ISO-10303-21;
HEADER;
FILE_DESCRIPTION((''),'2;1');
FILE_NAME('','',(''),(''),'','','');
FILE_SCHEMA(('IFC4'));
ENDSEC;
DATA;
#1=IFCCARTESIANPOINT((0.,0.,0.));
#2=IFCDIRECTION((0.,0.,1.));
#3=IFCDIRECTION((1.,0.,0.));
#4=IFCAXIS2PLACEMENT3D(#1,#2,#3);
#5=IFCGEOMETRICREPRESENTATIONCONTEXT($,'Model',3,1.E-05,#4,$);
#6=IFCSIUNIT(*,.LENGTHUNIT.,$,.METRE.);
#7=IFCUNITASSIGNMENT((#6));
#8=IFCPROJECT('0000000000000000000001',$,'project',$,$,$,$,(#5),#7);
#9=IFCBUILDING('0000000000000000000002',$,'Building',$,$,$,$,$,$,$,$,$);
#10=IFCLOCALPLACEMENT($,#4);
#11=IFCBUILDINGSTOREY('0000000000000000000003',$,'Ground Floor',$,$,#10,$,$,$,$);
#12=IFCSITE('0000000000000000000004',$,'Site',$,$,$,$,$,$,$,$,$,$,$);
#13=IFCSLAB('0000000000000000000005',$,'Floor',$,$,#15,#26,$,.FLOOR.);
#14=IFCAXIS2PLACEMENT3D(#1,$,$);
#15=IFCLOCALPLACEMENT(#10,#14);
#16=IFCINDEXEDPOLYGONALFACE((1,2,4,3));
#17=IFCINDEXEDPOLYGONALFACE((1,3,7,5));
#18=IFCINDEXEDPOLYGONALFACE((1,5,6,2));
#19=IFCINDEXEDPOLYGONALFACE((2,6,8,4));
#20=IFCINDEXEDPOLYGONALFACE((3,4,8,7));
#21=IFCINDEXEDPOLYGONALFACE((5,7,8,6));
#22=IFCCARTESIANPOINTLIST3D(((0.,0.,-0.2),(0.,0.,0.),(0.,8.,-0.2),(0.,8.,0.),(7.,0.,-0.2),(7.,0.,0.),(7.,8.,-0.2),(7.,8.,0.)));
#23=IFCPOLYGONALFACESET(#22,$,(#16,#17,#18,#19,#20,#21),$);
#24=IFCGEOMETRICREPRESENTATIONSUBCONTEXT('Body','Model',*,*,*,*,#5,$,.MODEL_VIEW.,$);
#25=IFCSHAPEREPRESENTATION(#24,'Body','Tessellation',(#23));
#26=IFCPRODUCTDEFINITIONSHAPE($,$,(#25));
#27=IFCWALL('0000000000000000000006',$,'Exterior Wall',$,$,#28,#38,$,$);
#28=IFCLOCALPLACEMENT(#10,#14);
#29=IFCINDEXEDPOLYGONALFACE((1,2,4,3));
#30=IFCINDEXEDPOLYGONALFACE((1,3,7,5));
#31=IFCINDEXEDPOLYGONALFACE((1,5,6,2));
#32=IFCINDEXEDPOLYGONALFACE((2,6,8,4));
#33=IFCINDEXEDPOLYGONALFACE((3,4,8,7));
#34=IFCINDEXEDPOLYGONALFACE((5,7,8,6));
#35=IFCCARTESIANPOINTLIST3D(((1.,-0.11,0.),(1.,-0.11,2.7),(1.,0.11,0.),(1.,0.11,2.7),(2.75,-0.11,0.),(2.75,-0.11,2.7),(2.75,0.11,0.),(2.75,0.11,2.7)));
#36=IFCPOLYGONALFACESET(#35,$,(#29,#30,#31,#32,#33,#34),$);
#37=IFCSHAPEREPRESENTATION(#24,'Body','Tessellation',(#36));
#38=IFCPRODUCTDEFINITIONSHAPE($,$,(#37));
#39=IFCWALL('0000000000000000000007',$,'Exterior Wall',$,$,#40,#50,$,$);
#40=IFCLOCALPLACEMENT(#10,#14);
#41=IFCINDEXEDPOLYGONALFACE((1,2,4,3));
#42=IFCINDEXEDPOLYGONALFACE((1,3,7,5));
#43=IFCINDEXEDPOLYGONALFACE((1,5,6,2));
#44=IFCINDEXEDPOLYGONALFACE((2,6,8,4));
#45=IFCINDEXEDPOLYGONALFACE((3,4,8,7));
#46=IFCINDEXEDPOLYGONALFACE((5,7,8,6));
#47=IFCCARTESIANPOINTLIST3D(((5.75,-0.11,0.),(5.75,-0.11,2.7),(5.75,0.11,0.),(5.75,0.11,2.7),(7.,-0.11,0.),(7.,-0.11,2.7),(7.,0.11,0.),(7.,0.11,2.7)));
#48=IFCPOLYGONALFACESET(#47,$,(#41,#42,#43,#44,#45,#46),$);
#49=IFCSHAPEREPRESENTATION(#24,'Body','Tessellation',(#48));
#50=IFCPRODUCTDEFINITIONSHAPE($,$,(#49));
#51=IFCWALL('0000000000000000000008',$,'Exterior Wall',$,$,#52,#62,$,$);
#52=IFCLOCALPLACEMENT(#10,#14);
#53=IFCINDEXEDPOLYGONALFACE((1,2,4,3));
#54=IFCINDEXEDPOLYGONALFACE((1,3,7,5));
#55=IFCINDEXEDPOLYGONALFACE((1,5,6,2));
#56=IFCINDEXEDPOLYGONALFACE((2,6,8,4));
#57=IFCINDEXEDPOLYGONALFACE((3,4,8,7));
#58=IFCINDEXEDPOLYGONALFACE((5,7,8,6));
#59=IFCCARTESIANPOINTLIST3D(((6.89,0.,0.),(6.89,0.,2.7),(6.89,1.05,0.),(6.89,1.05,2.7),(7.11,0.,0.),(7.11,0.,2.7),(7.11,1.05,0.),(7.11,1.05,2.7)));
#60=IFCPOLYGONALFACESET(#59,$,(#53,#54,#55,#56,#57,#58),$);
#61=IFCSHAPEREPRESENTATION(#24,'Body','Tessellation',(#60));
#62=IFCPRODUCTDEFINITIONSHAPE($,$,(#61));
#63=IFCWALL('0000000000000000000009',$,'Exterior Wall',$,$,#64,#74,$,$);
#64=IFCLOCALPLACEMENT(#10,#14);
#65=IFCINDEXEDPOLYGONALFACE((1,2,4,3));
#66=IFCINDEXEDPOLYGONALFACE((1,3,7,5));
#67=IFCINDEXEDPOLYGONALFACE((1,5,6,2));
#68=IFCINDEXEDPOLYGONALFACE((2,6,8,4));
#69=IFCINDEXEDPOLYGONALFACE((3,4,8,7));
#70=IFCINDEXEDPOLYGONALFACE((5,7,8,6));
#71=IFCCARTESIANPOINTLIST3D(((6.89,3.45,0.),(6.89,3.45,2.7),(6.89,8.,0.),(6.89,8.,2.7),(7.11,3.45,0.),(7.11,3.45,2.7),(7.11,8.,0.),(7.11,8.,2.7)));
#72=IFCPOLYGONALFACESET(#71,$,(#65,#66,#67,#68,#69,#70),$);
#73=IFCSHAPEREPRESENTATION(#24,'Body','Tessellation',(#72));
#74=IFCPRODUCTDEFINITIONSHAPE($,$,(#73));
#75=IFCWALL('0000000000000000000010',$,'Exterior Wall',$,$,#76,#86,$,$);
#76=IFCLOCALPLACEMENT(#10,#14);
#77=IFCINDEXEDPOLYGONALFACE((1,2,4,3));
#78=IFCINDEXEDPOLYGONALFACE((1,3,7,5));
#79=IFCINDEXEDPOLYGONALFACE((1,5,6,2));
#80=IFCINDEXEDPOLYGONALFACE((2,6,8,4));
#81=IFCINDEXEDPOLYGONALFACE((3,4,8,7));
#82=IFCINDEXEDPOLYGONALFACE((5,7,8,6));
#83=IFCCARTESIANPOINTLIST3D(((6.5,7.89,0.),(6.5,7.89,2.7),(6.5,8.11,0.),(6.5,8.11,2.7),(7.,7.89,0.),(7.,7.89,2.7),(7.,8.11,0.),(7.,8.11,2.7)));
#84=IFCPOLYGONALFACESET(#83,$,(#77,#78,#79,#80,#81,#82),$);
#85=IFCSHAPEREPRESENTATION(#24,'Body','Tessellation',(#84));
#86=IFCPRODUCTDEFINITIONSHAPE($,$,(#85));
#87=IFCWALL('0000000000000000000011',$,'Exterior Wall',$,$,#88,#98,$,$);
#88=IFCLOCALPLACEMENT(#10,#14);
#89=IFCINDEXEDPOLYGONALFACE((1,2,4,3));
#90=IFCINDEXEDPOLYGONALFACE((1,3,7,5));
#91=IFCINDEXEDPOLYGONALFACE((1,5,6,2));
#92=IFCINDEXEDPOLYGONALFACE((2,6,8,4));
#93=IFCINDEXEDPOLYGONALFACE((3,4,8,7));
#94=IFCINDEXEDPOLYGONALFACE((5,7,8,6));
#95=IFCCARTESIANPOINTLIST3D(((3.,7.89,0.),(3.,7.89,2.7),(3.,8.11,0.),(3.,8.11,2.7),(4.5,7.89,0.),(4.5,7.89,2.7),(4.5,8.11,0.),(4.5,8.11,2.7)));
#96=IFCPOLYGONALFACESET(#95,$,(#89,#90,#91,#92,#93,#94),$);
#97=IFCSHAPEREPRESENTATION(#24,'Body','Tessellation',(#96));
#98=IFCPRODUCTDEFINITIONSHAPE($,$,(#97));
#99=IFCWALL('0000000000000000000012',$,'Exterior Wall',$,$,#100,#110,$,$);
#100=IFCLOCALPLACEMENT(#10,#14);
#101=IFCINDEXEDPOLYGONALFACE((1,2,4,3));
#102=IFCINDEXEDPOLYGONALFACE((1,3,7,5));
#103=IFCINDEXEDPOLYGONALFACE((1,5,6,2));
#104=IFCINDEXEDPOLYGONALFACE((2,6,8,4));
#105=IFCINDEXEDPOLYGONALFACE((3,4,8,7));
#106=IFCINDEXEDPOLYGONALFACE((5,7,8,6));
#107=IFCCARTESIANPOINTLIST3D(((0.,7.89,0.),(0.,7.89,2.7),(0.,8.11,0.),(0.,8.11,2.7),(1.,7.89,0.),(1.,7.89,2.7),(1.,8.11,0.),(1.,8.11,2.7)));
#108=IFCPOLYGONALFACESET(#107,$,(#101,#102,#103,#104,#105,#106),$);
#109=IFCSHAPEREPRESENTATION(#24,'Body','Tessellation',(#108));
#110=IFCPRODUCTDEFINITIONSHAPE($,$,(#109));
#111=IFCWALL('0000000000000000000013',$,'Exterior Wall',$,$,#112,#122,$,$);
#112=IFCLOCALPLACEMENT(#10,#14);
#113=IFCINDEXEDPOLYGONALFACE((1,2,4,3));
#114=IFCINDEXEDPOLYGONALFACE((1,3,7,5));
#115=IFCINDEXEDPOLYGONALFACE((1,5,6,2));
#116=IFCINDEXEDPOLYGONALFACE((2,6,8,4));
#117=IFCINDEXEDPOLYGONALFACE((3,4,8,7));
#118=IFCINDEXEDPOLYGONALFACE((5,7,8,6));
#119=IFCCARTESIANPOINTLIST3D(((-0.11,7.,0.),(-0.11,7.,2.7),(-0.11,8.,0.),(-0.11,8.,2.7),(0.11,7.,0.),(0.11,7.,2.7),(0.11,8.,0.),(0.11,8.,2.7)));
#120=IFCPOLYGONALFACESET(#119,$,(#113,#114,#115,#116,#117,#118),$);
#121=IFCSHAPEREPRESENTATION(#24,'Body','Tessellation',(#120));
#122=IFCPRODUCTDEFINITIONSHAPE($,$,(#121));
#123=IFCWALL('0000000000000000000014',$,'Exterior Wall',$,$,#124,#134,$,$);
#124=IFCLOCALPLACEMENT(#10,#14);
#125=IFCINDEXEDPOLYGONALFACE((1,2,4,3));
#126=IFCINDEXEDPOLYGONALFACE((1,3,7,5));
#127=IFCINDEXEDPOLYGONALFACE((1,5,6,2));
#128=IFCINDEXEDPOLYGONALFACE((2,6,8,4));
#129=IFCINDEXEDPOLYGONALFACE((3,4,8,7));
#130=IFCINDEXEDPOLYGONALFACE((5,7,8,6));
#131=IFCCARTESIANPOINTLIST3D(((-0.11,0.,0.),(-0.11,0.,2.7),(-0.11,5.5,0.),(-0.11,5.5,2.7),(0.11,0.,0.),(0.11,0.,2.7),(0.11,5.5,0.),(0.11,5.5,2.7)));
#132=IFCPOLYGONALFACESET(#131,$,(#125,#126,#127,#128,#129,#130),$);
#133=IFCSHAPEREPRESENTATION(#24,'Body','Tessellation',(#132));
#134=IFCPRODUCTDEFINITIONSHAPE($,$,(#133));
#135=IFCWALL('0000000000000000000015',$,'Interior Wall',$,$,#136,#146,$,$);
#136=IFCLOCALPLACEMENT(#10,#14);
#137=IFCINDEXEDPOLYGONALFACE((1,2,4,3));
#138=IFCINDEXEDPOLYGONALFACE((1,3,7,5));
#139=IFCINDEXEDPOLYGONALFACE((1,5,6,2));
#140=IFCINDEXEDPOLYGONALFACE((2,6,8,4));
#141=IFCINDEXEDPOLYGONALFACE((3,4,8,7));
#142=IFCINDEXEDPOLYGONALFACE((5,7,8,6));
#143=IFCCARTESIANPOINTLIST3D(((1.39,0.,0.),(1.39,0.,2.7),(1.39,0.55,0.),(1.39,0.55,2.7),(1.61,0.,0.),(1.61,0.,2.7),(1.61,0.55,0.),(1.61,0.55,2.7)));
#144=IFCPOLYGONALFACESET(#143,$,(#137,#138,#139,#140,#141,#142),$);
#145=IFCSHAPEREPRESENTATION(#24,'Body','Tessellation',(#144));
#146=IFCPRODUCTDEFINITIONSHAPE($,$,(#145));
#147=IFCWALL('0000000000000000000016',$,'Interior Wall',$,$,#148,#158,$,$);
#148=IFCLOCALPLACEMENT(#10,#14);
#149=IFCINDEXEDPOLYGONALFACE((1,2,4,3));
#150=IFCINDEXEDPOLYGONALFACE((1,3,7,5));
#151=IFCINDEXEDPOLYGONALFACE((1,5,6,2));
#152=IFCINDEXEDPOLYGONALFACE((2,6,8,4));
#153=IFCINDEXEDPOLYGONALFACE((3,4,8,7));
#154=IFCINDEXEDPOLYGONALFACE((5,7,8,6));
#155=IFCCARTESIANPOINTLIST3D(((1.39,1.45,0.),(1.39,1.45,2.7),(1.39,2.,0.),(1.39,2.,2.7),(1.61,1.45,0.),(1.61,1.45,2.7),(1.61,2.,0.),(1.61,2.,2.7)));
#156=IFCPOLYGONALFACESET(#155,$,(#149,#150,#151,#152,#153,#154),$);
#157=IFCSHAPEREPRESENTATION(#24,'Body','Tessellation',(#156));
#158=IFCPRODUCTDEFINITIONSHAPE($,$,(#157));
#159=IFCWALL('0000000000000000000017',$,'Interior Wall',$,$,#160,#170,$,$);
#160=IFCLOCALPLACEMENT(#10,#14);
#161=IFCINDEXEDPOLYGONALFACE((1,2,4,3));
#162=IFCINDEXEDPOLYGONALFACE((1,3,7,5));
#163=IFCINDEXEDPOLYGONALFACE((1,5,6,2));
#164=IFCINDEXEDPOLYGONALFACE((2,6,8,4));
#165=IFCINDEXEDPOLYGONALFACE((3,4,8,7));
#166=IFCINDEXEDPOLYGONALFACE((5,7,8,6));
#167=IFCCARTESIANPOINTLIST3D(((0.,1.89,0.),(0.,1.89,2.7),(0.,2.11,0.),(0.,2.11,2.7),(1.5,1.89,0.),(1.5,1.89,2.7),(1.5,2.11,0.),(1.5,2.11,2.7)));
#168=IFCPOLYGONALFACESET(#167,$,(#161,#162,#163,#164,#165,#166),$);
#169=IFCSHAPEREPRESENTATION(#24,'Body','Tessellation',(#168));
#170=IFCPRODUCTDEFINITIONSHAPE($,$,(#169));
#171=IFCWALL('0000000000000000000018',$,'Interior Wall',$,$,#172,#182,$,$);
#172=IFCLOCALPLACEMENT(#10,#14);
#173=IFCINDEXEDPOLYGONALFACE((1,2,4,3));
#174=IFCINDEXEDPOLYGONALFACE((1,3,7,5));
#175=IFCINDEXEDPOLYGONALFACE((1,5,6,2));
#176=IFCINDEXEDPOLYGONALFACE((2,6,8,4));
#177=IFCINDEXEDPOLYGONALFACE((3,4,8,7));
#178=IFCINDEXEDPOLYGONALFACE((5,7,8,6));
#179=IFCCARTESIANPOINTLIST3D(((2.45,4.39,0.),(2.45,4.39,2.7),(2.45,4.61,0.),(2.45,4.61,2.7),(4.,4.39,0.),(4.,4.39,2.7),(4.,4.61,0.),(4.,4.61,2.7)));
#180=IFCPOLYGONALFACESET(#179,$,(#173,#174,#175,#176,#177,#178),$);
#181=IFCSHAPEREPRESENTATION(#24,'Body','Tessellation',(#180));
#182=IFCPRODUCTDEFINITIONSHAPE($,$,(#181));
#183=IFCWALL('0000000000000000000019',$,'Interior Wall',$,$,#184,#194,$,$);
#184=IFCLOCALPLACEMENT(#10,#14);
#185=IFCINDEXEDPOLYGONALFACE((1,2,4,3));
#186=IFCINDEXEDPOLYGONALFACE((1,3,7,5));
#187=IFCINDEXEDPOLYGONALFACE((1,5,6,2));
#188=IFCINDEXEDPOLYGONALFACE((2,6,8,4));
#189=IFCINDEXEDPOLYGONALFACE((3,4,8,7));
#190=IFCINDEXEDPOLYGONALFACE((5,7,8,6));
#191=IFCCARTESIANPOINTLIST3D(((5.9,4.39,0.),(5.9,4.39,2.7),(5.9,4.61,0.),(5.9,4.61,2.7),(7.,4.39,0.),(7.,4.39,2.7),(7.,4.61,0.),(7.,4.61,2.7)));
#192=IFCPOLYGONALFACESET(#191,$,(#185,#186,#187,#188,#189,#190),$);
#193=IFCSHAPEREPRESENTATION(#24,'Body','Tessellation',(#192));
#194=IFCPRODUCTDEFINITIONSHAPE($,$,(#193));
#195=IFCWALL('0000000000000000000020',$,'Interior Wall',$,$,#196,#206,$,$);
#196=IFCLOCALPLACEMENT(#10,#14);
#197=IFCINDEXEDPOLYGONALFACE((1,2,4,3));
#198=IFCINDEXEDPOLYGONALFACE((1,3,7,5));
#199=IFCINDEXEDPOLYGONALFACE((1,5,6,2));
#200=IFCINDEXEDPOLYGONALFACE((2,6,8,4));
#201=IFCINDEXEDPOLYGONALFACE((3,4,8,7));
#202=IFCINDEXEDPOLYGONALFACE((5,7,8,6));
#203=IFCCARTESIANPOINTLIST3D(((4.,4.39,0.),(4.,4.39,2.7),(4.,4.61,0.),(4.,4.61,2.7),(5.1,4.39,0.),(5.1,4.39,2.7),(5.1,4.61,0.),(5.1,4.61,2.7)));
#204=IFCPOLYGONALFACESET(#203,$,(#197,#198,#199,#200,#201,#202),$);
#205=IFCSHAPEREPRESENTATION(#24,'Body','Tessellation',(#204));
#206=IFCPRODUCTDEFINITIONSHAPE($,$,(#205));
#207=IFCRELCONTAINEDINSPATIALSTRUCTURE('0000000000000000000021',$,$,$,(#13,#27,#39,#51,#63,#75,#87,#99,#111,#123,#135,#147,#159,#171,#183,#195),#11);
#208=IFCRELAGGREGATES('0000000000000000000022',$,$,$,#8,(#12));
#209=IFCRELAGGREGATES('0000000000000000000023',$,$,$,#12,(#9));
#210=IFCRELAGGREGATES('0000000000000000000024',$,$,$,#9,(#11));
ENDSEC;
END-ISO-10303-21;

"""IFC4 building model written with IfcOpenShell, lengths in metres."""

from ifc_helpers import new_model, si_unit, frame, origin_with_axes, place, context, subcontext, project, spatial, indexed_curve, outline, extrude, element, save


model = new_model("IFC4")

# Units and contexts
model_context = context("Model", 3, precision=1e-05, world=origin_with_axes())
body_context = subcontext(model_context, "Body", "Model", "MODEL_VIEW")
ifc_project = project(units=[si_unit("LENGTHUNIT", "METRE")], contexts=[model_context])

# Site, building, storey
site = spatial("IfcSite", under=ifc_project, Name="Site")
building = spatial("IfcBuilding", under=site, Name="Building")
storey_placement = place(None, origin_with_axes())
storey = spatial("IfcBuildingStorey", under=building, at=storey_placement, Name="Ground Floor")

# Slab
slab_placement = place(storey_placement, frame((0.0, 0.0, -0.2), z_axis=(0.0, 0.0, 1.0), x_axis=(1.0, 0.0, 0.0)))
element("IfcSlab", 1, at=slab_placement, inside=storey, Name="Floor", PredefinedType="FLOOR", context=body_context, shape_type="SweptSolid", body=[
    extrude(outline(indexed_curve([(0.0, 0.0), (7.0, 0.0), (7.0, 8.0), (0.0, 8.0)])), None, (0.0, 0.0, 1.0), 0.2),
])

# Walls
wall_1_placement = place(storey_placement, frame((1.0, 0.0, 0.0), z_axis=(0.0, 0.0, 1.0), x_axis=(1.0, 0.0, 0.0)))
element("IfcWall", 2, at=wall_1_placement, inside=storey, Name="Exterior Wall", context=body_context, shape_type="SweptSolid", body=[
    extrude(outline(indexed_curve([(0.0, 0.0), (0.0, 0.22), (1.75, 0.22), (1.75, 0.0), (0.0, 0.0)], self_intersect=False)), frame((0.0, -0.11, 0.0), z_axis=(0.0, 0.0, 1.0), x_axis=(1.0, 0.0, 0.0)), (0.0, 0.0, 1.0), 2.7),
])
wall_2_placement = place(storey_placement, frame((5.75, 0.0, 0.0), z_axis=(0.0, 0.0, 1.0), x_axis=(1.0, 0.0, 0.0)))
element("IfcWall", 3, at=wall_2_placement, inside=storey, Name="Exterior Wall", context=body_context, shape_type="SweptSolid", body=[
    extrude(outline(indexed_curve([(0.0, 0.0), (0.0, 0.22), (1.25, 0.22), (1.25, 0.0), (0.0, 0.0)], self_intersect=False)), frame((0.0, -0.11, 0.0), z_axis=(0.0, 0.0, 1.0), x_axis=(1.0, 0.0, 0.0)), (0.0, 0.0, 1.0), 2.7),
])
wall_3_placement = place(storey_placement, frame((7.0, 0.0, 0.0), z_axis=(0.0, 0.0, 1.0), x_axis=(0.0, 1.0, 0.0)))
element("IfcWall", 4, at=wall_3_placement, inside=storey, Name="Exterior Wall", context=body_context, shape_type="SweptSolid", body=[
    extrude(outline(indexed_curve([(0.0, 0.0), (0.0, 0.22), (1.05, 0.22), (1.05, 0.0), (0.0, 0.0)], self_intersect=False)), frame((0.0, -0.11, 0.0), z_axis=(0.0, 0.0, 1.0), x_axis=(1.0, 0.0, 0.0)), (0.0, 0.0, 1.0), 2.7),
])
wall_4_placement = place(storey_placement, frame((7.0, 3.45, 0.0), z_axis=(0.0, 0.0, 1.0), x_axis=(0.0, 1.0, 0.0)))
element("IfcWall", 5, at=wall_4_placement, inside=storey, Name="Exterior Wall", context=body_context, shape_type="SweptSolid", body=[
    extrude(outline(indexed_curve([(0.0, 0.0), (0.0, 0.22), (4.55, 0.22), (4.55, 0.0), (0.0, 0.0)], self_intersect=False)), frame((0.0, -0.11, 0.0), z_axis=(0.0, 0.0, 1.0), x_axis=(1.0, 0.0, 0.0)), (0.0, 0.0, 1.0), 2.7),
])
wall_5_placement = place(storey_placement, frame((7.0, 8.0, 0.0), z_axis=(0.0, 0.0, 1.0), x_axis=(-1.0, 0.0, 0.0)))
element("IfcWall", 6, at=wall_5_placement, inside=storey, Name="Exterior Wall", context=body_context, shape_type="SweptSolid", body=[
    extrude(outline(indexed_curve([(0.0, 0.0), (0.0, 0.22), (0.5, 0.22), (0.5, 0.0), (0.0, 0.0)], self_intersect=False)), frame((0.0, -0.11, 0.0), z_axis=(0.0, 0.0, 1.0), x_axis=(1.0, 0.0, 0.0)), (0.0, 0.0, 1.0), 2.7),
])
wall_6_placement = place(storey_placement, frame((4.5, 8.0, 0.0), z_axis=(0.0, 0.0, 1.0), x_axis=(-1.0, 0.0, 0.0)))
element("IfcWall", 7, at=wall_6_placement, inside=storey, Name="Exterior Wall", context=body_context, shape_type="SweptSolid", body=[
    extrude(outline(indexed_curve([(0.0, 0.0), (0.0, 0.22), (1.5, 0.22), (1.5, 0.0), (0.0, 0.0)], self_intersect=False)), frame((0.0, -0.11, 0.0), z_axis=(0.0, 0.0, 1.0), x_axis=(1.0, 0.0, 0.0)), (0.0, 0.0, 1.0), 2.7),
])
for number, where, z_axis, x_axis, name in (
    (8, (1.0, 8.0, 0.0), (0.0, 0.0, 1.0), (-1.0, 0.0, 0.0), "Exterior Wall"),
    (9, (0.0, 8.0, 0.0), (0.0, 0.0, 1.0), (0.0, -1.0, 0.0), "Exterior Wall"),
):
    element("IfcWall", number, at=place(storey_placement, frame(where, z_axis=z_axis, x_axis=x_axis)), inside=storey, Name=name, context=body_context, shape_type="SweptSolid", body=[
        extrude(outline(indexed_curve([(0.0, 0.0), (0.0, 0.22), (1.0, 0.22), (1.0, 0.0), (0.0, 0.0)], self_intersect=False)), frame((0.0, -0.11, 0.0), z_axis=(0.0, 0.0, 1.0), x_axis=(1.0, 0.0, 0.0)), (0.0, 0.0, 1.0), 2.7),
    ])
wall_7_placement = place(storey_placement, frame((0.0, 5.5, 0.0), z_axis=(0.0, 0.0, 1.0), x_axis=(0.0, -1.0, 0.0)))
element("IfcWall", 10, at=wall_7_placement, inside=storey, Name="Exterior Wall", context=body_context, shape_type="SweptSolid", body=[
    extrude(outline(indexed_curve([(0.0, 0.0), (0.0, 0.22), (5.5, 0.22), (5.5, 0.0), (0.0, 0.0)], self_intersect=False)), frame((0.0, -0.11, 0.0), z_axis=(0.0, 0.0, 1.0), x_axis=(1.0, 0.0, 0.0)), (0.0, 0.0, 1.0), 2.7),
])
for number, where, z_axis, x_axis, name in (
    (11, (1.5, 0.0, 0.0), (0.0, 0.0, 1.0), (0.0, 1.0, 0.0), "Interior Wall"),
    (12, (1.5, 1.45, 0.0), (0.0, 0.0, 1.0), (0.0, 1.0, 0.0), "Interior Wall"),
):
    element("IfcWall", number, at=place(storey_placement, frame(where, z_axis=z_axis, x_axis=x_axis)), inside=storey, Name=name, context=body_context, shape_type="SweptSolid", body=[
        extrude(outline(indexed_curve([(0.0, 0.0), (0.0, 0.22), (0.55, 0.22), (0.55, 0.0), (0.0, 0.0)], self_intersect=False)), frame((0.0, -0.11, 0.0), z_axis=(0.0, 0.0, 1.0), x_axis=(1.0, 0.0, 0.0)), (0.0, 0.0, 1.0), 2.7),
    ])
wall_8_placement = place(storey_placement, frame((1.5, 2.0, 0.0), z_axis=(0.0, 0.0, 1.0), x_axis=(-1.0, 0.0, 0.0)))
element("IfcWall", 13, at=wall_8_placement, inside=storey, Name="Interior Wall", context=body_context, shape_type="SweptSolid", body=[
    extrude(outline(indexed_curve([(0.0, 0.0), (0.0, 0.22), (1.5, 0.22), (1.5, 0.0), (0.0, 0.0)], self_intersect=False)), frame((0.0, -0.11, 0.0), z_axis=(0.0, 0.0, 1.0), x_axis=(1.0, 0.0, 0.0)), (0.0, 0.0, 1.0), 2.7),
])
wall_9_placement = place(storey_placement, frame((4.0, 4.5, 0.0), z_axis=(0.0, 0.0, 1.0), x_axis=(-1.0, 0.0, 0.0)))
element("IfcWall", 14, at=wall_9_placement, inside=storey, Name="Interior Wall", context=body_context, shape_type="SweptSolid", body=[
    extrude(outline(indexed_curve([(0.0, 0.0), (0.0, 0.22), (1.55, 0.22), (1.55, 0.0), (0.0, 0.0)], self_intersect=False)), frame((0.0, -0.11, 0.0), z_axis=(0.0, 0.0, 1.0), x_axis=(1.0, 0.0, 0.0)), (0.0, 0.0, 1.0), 2.7),
])
for number, where, z_axis, x_axis, name in (
    (15, (7.0, 4.5, 0.0), (0.0, 0.0, 1.0), (-1.0, 0.0, 0.0), "Interior Wall"),
    (16, (5.1, 4.5, 0.0), (0.0, 0.0, 1.0), (-1.0, 0.0, 0.0), "Interior Wall"),
):
    element("IfcWall", number, at=place(storey_placement, frame(where, z_axis=z_axis, x_axis=x_axis)), inside=storey, Name=name, context=body_context, shape_type="SweptSolid", body=[
        extrude(outline(indexed_curve([(0.0, 0.0), (0.0, 0.22), (1.1, 0.22), (1.1, 0.0), (0.0, 0.0)], self_intersect=False)), frame((0.0, -0.11, 0.0), z_axis=(0.0, 0.0, 1.0), x_axis=(1.0, 0.0, 0.0)), (0.0, 0.0, 1.0), 2.7),
    ])

save(model, "model.ifc")
